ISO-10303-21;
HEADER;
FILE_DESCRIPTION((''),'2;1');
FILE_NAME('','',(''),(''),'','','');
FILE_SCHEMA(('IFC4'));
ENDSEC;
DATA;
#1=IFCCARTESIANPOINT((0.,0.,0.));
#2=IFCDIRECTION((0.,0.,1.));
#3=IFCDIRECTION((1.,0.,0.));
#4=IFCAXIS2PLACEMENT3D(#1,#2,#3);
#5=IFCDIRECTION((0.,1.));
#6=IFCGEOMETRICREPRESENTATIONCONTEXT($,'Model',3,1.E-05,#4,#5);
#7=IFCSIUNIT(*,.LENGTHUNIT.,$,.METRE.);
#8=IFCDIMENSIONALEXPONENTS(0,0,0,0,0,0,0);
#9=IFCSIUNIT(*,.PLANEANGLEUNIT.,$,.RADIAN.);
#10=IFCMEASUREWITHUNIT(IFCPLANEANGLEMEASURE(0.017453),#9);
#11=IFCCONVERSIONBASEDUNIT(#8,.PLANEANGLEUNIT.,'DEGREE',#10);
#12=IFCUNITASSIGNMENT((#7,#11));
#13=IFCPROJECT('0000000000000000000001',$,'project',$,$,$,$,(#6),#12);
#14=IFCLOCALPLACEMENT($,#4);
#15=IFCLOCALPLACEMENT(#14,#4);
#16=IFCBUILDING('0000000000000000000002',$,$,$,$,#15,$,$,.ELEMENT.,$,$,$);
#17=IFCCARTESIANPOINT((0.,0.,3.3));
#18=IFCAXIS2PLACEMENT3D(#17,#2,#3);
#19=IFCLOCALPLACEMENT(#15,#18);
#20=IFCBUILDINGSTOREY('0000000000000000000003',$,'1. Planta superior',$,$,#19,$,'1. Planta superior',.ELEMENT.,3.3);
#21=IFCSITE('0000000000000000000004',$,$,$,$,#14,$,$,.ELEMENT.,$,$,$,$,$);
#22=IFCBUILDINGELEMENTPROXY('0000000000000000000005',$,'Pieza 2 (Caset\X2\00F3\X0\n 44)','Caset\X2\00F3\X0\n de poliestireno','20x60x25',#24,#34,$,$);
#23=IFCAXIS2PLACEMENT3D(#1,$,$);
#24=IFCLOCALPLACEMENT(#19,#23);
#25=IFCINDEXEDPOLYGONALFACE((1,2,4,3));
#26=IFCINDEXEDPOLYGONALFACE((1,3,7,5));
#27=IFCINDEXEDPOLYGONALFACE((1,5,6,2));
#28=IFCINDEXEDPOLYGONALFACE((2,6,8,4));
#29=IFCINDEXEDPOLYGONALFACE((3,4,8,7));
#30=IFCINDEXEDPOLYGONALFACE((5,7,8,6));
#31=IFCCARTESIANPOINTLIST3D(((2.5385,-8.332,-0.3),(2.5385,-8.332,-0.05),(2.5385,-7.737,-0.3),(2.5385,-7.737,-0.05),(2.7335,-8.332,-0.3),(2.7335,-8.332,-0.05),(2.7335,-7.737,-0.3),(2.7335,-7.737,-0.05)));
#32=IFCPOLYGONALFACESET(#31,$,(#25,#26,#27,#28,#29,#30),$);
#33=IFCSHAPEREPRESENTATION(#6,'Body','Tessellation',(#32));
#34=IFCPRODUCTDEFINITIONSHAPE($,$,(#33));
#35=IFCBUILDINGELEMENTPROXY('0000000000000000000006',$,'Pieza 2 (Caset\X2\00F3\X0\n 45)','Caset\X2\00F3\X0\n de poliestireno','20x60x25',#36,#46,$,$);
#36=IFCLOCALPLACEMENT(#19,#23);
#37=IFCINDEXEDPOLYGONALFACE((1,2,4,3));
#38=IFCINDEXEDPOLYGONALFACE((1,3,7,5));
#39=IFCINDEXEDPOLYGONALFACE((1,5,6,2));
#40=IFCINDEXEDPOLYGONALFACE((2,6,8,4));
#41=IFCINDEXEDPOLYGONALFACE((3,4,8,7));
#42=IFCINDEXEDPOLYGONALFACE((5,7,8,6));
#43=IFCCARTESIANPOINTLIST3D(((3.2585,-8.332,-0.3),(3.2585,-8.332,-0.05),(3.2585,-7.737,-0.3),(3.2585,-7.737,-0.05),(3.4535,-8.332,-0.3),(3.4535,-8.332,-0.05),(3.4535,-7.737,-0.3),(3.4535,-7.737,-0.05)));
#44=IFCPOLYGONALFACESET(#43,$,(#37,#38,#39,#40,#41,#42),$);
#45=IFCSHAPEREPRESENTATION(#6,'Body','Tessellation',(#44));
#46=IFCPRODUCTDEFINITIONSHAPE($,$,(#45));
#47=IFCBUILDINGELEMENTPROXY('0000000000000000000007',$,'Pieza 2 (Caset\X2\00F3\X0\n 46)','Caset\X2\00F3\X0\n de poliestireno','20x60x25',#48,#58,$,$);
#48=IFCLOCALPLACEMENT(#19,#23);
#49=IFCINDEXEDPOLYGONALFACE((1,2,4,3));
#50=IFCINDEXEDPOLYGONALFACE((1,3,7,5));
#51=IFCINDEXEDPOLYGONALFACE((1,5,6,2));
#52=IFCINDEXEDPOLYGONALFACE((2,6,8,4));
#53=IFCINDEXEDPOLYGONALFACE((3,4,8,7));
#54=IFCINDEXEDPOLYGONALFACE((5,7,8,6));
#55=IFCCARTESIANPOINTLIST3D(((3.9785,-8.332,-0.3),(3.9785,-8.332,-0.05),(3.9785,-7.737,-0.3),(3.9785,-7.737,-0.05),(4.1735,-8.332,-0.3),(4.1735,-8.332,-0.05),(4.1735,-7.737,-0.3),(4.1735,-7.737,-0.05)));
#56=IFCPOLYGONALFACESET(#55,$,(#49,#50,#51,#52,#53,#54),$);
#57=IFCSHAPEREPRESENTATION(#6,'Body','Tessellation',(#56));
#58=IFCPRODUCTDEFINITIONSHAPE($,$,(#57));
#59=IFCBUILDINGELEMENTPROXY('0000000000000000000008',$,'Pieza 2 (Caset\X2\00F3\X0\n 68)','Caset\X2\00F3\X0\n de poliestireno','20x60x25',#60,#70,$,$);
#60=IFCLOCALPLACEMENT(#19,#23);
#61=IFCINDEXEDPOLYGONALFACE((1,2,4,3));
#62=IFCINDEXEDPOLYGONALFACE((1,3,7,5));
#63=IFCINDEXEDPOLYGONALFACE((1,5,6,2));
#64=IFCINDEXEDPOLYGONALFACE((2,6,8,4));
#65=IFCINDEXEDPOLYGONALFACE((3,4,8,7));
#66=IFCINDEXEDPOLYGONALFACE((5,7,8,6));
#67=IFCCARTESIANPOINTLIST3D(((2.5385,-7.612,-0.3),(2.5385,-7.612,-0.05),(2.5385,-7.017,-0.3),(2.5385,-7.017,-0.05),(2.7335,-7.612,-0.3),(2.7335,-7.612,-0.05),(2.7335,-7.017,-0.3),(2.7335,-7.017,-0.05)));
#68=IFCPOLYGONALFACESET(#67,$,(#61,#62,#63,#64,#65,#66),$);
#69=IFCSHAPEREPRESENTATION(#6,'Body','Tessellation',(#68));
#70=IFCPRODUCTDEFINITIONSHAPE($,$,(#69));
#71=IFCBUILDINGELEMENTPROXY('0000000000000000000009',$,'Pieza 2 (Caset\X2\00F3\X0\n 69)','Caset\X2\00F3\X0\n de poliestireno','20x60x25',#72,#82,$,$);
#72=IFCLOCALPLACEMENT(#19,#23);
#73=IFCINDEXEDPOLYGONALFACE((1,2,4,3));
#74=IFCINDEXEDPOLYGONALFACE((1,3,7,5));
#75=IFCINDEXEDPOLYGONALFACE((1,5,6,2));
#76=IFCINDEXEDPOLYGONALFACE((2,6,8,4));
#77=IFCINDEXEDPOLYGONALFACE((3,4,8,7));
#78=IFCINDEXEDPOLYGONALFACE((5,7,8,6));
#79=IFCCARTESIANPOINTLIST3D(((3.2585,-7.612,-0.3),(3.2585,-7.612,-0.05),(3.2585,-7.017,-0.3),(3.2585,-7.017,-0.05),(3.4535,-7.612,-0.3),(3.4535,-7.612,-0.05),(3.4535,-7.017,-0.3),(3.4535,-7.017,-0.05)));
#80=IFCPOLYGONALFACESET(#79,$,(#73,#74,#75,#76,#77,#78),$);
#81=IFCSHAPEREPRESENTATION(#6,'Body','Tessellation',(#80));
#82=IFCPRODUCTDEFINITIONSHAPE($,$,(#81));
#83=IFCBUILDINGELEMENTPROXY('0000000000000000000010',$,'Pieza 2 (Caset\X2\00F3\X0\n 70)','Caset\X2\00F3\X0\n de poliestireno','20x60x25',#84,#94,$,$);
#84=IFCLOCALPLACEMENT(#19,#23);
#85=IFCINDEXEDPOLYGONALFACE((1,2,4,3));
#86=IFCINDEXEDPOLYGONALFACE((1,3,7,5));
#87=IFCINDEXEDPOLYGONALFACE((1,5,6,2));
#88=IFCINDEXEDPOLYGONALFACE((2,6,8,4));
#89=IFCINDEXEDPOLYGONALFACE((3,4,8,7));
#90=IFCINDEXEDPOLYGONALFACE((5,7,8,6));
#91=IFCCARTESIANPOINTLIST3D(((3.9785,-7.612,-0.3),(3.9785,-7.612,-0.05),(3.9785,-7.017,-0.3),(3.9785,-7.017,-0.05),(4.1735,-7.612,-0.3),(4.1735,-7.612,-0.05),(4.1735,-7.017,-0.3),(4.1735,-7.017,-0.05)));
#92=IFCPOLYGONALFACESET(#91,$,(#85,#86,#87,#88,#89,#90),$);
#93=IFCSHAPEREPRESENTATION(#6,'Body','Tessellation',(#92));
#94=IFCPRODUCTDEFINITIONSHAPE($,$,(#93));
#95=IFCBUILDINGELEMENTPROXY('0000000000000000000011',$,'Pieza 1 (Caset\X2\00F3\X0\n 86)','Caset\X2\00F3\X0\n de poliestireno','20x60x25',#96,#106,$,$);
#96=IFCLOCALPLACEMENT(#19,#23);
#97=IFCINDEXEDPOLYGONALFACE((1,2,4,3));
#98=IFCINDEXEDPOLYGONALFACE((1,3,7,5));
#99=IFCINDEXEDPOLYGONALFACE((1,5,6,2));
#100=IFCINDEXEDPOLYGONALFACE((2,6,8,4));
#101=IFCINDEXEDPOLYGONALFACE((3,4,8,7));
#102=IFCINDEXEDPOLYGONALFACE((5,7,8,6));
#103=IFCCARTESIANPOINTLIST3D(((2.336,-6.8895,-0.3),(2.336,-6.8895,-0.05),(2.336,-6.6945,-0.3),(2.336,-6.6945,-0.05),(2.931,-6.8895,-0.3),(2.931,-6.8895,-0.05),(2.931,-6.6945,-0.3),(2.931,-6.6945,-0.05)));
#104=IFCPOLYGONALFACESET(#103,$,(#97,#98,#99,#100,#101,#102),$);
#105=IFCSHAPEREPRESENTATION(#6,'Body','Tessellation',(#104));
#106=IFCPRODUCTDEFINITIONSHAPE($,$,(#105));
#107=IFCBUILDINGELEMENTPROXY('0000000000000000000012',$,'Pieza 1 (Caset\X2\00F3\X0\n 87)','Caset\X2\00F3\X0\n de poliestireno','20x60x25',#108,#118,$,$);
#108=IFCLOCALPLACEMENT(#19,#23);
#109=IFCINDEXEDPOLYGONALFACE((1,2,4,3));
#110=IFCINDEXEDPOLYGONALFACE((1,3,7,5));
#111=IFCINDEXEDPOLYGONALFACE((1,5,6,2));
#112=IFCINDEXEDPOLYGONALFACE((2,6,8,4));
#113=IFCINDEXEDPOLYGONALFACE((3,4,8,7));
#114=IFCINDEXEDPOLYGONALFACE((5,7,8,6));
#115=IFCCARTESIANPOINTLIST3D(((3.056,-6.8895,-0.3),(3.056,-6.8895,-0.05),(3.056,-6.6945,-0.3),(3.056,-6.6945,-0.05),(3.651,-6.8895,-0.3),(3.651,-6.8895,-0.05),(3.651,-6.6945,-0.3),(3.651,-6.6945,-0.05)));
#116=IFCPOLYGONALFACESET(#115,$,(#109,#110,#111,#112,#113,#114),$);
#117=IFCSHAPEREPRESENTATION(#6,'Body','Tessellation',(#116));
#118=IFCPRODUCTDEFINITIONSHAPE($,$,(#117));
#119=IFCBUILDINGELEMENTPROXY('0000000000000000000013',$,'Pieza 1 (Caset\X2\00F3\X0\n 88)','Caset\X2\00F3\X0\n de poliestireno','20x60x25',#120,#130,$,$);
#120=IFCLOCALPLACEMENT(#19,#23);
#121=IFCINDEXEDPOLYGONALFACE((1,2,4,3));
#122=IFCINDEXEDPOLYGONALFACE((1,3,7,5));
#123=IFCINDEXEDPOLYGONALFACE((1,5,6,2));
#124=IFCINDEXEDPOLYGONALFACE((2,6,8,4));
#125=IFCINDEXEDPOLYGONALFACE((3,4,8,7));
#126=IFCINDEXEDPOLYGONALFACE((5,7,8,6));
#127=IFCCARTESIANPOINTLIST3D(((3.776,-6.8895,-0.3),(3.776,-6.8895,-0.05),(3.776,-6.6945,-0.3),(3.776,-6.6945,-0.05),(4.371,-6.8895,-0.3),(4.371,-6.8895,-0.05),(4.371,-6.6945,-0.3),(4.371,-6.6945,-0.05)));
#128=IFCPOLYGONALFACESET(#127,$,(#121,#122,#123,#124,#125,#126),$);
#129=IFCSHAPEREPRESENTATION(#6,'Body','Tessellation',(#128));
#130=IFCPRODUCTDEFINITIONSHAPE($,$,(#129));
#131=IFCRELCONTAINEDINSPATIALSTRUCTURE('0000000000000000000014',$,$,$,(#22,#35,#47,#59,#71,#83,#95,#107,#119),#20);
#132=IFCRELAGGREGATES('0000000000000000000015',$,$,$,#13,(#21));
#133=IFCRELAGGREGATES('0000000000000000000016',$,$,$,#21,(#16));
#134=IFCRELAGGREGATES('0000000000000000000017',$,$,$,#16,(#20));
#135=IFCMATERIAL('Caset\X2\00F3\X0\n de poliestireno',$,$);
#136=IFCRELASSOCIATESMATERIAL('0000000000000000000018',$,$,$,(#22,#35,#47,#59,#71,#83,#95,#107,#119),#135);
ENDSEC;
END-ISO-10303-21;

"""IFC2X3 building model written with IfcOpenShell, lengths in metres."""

from ifc_helpers import new_model, entity, si_unit, converted_unit, direction, frame, origin_with_axes, origin_2d_with_axis, place, context, project, spatial, rectangle, extrude, source, transform, mapped, material, element, save


model = new_model("IFC2X3")

# Units and contexts
model_context = context("Model", 3, precision=1e-05, world=origin_with_axes(), true_north=direction((0.0, 1.0)))
ifc_project = project(units=[si_unit("LENGTHUNIT", "METRE"), converted_unit("PLANEANGLEUNIT", "DEGREE", entity("IfcPlaneAngleMeasure", 0.017453), si_unit("PLANEANGLEUNIT", "RADIAN"), dimensions=[0, 0, 0, 0, 0, 0, 0])], contexts=[model_context])

# Site, building, storey
site_placement = place(None, origin_with_axes())
site = spatial("IfcSite", under=ifc_project, at=site_placement, CompositionType="ELEMENT")
building_placement = place(site_placement, origin_with_axes())
building = spatial("IfcBuilding", under=site, at=building_placement, CompositionType="ELEMENT")
storey_placement = place(building_placement, frame((0.0, 0.0, 3.3), z_axis=(0.0, 0.0, 1.0), x_axis=(1.0, 0.0, 0.0)))
storey = spatial("IfcBuildingStorey", under=building, at=storey_placement, Name="1. Planta superior", LongName="1. Planta superior", CompositionType="ELEMENT", Elevation=3.3)

# Building element proxies
ifc_material = material(Name="Casetón de poliestireno")
shared_shape = source(origin_with_axes(), model_context, "Body", "SweptSolid", [
    extrude(rectangle(XDim=0.195, YDim=0.25, at=origin_2d_with_axis()), origin_with_axes(), (0.0, 0.0, 1.0), 0.595),
])
placement_1 = place(storey_placement, frame((2.636, -8.332, -0.175), z_axis=(0.0, 1.0, 0.0), x_axis=(-1.0, 0.0, 0.0)))
for number, where, z_axis, x_axis, name in (
    (1, (0.0, 0.0, 0.0), (0.0, 0.0, 1.0), (1.0, 0.0, 0.0), "Pieza 2 (Casetón 44)"),
):
    element("IfcBuildingElementProxy", number, at=place(placement_1, frame(where, z_axis=z_axis, x_axis=x_axis)), inside=storey, material=ifc_material, Name=name, Description="Casetón de poliestireno", ObjectType="20x60x25", context=model_context, shape_type="MappedRepresentation", body=[
        mapped(shared_shape, transform((0.0, 0.0, 0.0), x_axis=(1.0, 0.0, 0.0), y_axis=(0.0, 1.0, 0.0), z_axis=(0.0, 0.0, 1.0))),
    ])
placement_2 = place(storey_placement, frame((3.356, -8.332, -0.175), z_axis=(0.0, 1.0, 0.0), x_axis=(-1.0, 0.0, 0.0)))
for number, where, z_axis, x_axis, name in (
    (2, (0.0, 0.0, 0.0), (0.0, 0.0, 1.0), (1.0, 0.0, 0.0), "Pieza 2 (Casetón 45)"),
):
    element("IfcBuildingElementProxy", number, at=place(placement_2, frame(where, z_axis=z_axis, x_axis=x_axis)), inside=storey, material=ifc_material, Name=name, Description="Casetón de poliestireno", ObjectType="20x60x25", context=model_context, shape_type="MappedRepresentation", body=[
        mapped(shared_shape, transform((0.0, 0.0, 0.0), x_axis=(1.0, 0.0, 0.0), y_axis=(0.0, 1.0, 0.0), z_axis=(0.0, 0.0, 1.0))),
    ])
placement_3 = place(storey_placement, frame((4.076, -8.332, -0.175), z_axis=(0.0, 1.0, 0.0), x_axis=(-1.0, 0.0, 0.0)))
for number, where, z_axis, x_axis, name in (
    (3, (0.0, 0.0, 0.0), (0.0, 0.0, 1.0), (1.0, 0.0, 0.0), "Pieza 2 (Casetón 46)"),
):
    element("IfcBuildingElementProxy", number, at=place(placement_3, frame(where, z_axis=z_axis, x_axis=x_axis)), inside=storey, material=ifc_material, Name=name, Description="Casetón de poliestireno", ObjectType="20x60x25", context=model_context, shape_type="MappedRepresentation", body=[
        mapped(shared_shape, transform((0.0, 0.0, 0.0), x_axis=(1.0, 0.0, 0.0), y_axis=(0.0, 1.0, 0.0), z_axis=(0.0, 0.0, 1.0))),
    ])
placement_4 = place(storey_placement, frame((2.636, -7.612, -0.175), z_axis=(0.0, 1.0, 0.0), x_axis=(-1.0, 0.0, 0.0)))
for number, where, z_axis, x_axis, name in (
    (4, (0.0, 0.0, 0.0), (0.0, 0.0, 1.0), (1.0, 0.0, 0.0), "Pieza 2 (Casetón 68)"),
):
    element("IfcBuildingElementProxy", number, at=place(placement_4, frame(where, z_axis=z_axis, x_axis=x_axis)), inside=storey, material=ifc_material, Name=name, Description="Casetón de poliestireno", ObjectType="20x60x25", context=model_context, shape_type="MappedRepresentation", body=[
        mapped(shared_shape, transform((0.0, 0.0, 0.0), x_axis=(1.0, 0.0, 0.0), y_axis=(0.0, 1.0, 0.0), z_axis=(0.0, 0.0, 1.0))),
    ])
placement_5 = place(storey_placement, frame((3.356, -7.612, -0.175), z_axis=(0.0, 1.0, 0.0), x_axis=(-1.0, 0.0, 0.0)))
for number, where, z_axis, x_axis, name in (
    (5, (0.0, 0.0, 0.0), (0.0, 0.0, 1.0), (1.0, 0.0, 0.0), "Pieza 2 (Casetón 69)"),
):
    element("IfcBuildingElementProxy", number, at=place(placement_5, frame(where, z_axis=z_axis, x_axis=x_axis)), inside=storey, material=ifc_material, Name=name, Description="Casetón de poliestireno", ObjectType="20x60x25", context=model_context, shape_type="MappedRepresentation", body=[
        mapped(shared_shape, transform((0.0, 0.0, 0.0), x_axis=(1.0, 0.0, 0.0), y_axis=(0.0, 1.0, 0.0), z_axis=(0.0, 0.0, 1.0))),
    ])
placement_6 = place(storey_placement, frame((4.076, -7.612, -0.175), z_axis=(0.0, 1.0, 0.0), x_axis=(-1.0, 0.0, 0.0)))
for number, where, z_axis, x_axis, name in (
    (6, (0.0, 0.0, 0.0), (0.0, 0.0, 1.0), (1.0, 0.0, 0.0), "Pieza 2 (Casetón 70)"),
):
    element("IfcBuildingElementProxy", number, at=place(placement_6, frame(where, z_axis=z_axis, x_axis=x_axis)), inside=storey, material=ifc_material, Name=name, Description="Casetón de poliestireno", ObjectType="20x60x25", context=model_context, shape_type="MappedRepresentation", body=[
        mapped(shared_shape, transform((0.0, 0.0, 0.0), x_axis=(1.0, 0.0, 0.0), y_axis=(0.0, 1.0, 0.0), z_axis=(0.0, 0.0, 1.0))),
    ])
placement_7 = place(storey_placement, frame((2.336, -6.792, -0.175), z_axis=(1.0, 0.0, 0.0), x_axis=(0.0, 1.0, 0.0)))
proxy_1_placement = place(placement_7, origin_with_axes())
element("IfcBuildingElementProxy", 7, at=proxy_1_placement, inside=storey, material=ifc_material, Name="Pieza 1 (Casetón 86)", Description="Casetón de poliestireno", ObjectType="20x60x25", context=model_context, shape_type="MappedRepresentation", body=[
    mapped(shared_shape, transform((0.0, 0.0, 0.0), x_axis=(1.0, 0.0, 0.0), y_axis=(0.0, 1.0, 0.0), z_axis=(0.0, 0.0, 1.0))),
])
placement_8 = place(storey_placement, frame((3.056, -6.792, -0.175), z_axis=(1.0, 0.0, 0.0), x_axis=(0.0, 1.0, 0.0)))
proxy_2_placement = place(placement_8, origin_with_axes())
element("IfcBuildingElementProxy", 8, at=proxy_2_placement, inside=storey, material=ifc_material, Name="Pieza 1 (Casetón 87)", Description="Casetón de poliestireno", ObjectType="20x60x25", context=model_context, shape_type="MappedRepresentation", body=[
    mapped(shared_shape, transform((0.0, 0.0, 0.0), x_axis=(1.0, 0.0, 0.0), y_axis=(0.0, 1.0, 0.0), z_axis=(0.0, 0.0, 1.0))),
])
placement_9 = place(storey_placement, frame((3.776, -6.792, -0.175), z_axis=(1.0, 0.0, 0.0), x_axis=(0.0, 1.0, 0.0)))
proxy_3_placement = place(placement_9, origin_with_axes())
element("IfcBuildingElementProxy", 9, at=proxy_3_placement, inside=storey, material=ifc_material, Name="Pieza 1 (Casetón 88)", Description="Casetón de poliestireno", ObjectType="20x60x25", context=model_context, shape_type="MappedRepresentation", body=[
    mapped(shared_shape, transform((0.0, 0.0, 0.0), x_axis=(1.0, 0.0, 0.0), y_axis=(0.0, 1.0, 0.0), z_axis=(0.0, 0.0, 1.0))),
])

save(model, "model.ifc")
